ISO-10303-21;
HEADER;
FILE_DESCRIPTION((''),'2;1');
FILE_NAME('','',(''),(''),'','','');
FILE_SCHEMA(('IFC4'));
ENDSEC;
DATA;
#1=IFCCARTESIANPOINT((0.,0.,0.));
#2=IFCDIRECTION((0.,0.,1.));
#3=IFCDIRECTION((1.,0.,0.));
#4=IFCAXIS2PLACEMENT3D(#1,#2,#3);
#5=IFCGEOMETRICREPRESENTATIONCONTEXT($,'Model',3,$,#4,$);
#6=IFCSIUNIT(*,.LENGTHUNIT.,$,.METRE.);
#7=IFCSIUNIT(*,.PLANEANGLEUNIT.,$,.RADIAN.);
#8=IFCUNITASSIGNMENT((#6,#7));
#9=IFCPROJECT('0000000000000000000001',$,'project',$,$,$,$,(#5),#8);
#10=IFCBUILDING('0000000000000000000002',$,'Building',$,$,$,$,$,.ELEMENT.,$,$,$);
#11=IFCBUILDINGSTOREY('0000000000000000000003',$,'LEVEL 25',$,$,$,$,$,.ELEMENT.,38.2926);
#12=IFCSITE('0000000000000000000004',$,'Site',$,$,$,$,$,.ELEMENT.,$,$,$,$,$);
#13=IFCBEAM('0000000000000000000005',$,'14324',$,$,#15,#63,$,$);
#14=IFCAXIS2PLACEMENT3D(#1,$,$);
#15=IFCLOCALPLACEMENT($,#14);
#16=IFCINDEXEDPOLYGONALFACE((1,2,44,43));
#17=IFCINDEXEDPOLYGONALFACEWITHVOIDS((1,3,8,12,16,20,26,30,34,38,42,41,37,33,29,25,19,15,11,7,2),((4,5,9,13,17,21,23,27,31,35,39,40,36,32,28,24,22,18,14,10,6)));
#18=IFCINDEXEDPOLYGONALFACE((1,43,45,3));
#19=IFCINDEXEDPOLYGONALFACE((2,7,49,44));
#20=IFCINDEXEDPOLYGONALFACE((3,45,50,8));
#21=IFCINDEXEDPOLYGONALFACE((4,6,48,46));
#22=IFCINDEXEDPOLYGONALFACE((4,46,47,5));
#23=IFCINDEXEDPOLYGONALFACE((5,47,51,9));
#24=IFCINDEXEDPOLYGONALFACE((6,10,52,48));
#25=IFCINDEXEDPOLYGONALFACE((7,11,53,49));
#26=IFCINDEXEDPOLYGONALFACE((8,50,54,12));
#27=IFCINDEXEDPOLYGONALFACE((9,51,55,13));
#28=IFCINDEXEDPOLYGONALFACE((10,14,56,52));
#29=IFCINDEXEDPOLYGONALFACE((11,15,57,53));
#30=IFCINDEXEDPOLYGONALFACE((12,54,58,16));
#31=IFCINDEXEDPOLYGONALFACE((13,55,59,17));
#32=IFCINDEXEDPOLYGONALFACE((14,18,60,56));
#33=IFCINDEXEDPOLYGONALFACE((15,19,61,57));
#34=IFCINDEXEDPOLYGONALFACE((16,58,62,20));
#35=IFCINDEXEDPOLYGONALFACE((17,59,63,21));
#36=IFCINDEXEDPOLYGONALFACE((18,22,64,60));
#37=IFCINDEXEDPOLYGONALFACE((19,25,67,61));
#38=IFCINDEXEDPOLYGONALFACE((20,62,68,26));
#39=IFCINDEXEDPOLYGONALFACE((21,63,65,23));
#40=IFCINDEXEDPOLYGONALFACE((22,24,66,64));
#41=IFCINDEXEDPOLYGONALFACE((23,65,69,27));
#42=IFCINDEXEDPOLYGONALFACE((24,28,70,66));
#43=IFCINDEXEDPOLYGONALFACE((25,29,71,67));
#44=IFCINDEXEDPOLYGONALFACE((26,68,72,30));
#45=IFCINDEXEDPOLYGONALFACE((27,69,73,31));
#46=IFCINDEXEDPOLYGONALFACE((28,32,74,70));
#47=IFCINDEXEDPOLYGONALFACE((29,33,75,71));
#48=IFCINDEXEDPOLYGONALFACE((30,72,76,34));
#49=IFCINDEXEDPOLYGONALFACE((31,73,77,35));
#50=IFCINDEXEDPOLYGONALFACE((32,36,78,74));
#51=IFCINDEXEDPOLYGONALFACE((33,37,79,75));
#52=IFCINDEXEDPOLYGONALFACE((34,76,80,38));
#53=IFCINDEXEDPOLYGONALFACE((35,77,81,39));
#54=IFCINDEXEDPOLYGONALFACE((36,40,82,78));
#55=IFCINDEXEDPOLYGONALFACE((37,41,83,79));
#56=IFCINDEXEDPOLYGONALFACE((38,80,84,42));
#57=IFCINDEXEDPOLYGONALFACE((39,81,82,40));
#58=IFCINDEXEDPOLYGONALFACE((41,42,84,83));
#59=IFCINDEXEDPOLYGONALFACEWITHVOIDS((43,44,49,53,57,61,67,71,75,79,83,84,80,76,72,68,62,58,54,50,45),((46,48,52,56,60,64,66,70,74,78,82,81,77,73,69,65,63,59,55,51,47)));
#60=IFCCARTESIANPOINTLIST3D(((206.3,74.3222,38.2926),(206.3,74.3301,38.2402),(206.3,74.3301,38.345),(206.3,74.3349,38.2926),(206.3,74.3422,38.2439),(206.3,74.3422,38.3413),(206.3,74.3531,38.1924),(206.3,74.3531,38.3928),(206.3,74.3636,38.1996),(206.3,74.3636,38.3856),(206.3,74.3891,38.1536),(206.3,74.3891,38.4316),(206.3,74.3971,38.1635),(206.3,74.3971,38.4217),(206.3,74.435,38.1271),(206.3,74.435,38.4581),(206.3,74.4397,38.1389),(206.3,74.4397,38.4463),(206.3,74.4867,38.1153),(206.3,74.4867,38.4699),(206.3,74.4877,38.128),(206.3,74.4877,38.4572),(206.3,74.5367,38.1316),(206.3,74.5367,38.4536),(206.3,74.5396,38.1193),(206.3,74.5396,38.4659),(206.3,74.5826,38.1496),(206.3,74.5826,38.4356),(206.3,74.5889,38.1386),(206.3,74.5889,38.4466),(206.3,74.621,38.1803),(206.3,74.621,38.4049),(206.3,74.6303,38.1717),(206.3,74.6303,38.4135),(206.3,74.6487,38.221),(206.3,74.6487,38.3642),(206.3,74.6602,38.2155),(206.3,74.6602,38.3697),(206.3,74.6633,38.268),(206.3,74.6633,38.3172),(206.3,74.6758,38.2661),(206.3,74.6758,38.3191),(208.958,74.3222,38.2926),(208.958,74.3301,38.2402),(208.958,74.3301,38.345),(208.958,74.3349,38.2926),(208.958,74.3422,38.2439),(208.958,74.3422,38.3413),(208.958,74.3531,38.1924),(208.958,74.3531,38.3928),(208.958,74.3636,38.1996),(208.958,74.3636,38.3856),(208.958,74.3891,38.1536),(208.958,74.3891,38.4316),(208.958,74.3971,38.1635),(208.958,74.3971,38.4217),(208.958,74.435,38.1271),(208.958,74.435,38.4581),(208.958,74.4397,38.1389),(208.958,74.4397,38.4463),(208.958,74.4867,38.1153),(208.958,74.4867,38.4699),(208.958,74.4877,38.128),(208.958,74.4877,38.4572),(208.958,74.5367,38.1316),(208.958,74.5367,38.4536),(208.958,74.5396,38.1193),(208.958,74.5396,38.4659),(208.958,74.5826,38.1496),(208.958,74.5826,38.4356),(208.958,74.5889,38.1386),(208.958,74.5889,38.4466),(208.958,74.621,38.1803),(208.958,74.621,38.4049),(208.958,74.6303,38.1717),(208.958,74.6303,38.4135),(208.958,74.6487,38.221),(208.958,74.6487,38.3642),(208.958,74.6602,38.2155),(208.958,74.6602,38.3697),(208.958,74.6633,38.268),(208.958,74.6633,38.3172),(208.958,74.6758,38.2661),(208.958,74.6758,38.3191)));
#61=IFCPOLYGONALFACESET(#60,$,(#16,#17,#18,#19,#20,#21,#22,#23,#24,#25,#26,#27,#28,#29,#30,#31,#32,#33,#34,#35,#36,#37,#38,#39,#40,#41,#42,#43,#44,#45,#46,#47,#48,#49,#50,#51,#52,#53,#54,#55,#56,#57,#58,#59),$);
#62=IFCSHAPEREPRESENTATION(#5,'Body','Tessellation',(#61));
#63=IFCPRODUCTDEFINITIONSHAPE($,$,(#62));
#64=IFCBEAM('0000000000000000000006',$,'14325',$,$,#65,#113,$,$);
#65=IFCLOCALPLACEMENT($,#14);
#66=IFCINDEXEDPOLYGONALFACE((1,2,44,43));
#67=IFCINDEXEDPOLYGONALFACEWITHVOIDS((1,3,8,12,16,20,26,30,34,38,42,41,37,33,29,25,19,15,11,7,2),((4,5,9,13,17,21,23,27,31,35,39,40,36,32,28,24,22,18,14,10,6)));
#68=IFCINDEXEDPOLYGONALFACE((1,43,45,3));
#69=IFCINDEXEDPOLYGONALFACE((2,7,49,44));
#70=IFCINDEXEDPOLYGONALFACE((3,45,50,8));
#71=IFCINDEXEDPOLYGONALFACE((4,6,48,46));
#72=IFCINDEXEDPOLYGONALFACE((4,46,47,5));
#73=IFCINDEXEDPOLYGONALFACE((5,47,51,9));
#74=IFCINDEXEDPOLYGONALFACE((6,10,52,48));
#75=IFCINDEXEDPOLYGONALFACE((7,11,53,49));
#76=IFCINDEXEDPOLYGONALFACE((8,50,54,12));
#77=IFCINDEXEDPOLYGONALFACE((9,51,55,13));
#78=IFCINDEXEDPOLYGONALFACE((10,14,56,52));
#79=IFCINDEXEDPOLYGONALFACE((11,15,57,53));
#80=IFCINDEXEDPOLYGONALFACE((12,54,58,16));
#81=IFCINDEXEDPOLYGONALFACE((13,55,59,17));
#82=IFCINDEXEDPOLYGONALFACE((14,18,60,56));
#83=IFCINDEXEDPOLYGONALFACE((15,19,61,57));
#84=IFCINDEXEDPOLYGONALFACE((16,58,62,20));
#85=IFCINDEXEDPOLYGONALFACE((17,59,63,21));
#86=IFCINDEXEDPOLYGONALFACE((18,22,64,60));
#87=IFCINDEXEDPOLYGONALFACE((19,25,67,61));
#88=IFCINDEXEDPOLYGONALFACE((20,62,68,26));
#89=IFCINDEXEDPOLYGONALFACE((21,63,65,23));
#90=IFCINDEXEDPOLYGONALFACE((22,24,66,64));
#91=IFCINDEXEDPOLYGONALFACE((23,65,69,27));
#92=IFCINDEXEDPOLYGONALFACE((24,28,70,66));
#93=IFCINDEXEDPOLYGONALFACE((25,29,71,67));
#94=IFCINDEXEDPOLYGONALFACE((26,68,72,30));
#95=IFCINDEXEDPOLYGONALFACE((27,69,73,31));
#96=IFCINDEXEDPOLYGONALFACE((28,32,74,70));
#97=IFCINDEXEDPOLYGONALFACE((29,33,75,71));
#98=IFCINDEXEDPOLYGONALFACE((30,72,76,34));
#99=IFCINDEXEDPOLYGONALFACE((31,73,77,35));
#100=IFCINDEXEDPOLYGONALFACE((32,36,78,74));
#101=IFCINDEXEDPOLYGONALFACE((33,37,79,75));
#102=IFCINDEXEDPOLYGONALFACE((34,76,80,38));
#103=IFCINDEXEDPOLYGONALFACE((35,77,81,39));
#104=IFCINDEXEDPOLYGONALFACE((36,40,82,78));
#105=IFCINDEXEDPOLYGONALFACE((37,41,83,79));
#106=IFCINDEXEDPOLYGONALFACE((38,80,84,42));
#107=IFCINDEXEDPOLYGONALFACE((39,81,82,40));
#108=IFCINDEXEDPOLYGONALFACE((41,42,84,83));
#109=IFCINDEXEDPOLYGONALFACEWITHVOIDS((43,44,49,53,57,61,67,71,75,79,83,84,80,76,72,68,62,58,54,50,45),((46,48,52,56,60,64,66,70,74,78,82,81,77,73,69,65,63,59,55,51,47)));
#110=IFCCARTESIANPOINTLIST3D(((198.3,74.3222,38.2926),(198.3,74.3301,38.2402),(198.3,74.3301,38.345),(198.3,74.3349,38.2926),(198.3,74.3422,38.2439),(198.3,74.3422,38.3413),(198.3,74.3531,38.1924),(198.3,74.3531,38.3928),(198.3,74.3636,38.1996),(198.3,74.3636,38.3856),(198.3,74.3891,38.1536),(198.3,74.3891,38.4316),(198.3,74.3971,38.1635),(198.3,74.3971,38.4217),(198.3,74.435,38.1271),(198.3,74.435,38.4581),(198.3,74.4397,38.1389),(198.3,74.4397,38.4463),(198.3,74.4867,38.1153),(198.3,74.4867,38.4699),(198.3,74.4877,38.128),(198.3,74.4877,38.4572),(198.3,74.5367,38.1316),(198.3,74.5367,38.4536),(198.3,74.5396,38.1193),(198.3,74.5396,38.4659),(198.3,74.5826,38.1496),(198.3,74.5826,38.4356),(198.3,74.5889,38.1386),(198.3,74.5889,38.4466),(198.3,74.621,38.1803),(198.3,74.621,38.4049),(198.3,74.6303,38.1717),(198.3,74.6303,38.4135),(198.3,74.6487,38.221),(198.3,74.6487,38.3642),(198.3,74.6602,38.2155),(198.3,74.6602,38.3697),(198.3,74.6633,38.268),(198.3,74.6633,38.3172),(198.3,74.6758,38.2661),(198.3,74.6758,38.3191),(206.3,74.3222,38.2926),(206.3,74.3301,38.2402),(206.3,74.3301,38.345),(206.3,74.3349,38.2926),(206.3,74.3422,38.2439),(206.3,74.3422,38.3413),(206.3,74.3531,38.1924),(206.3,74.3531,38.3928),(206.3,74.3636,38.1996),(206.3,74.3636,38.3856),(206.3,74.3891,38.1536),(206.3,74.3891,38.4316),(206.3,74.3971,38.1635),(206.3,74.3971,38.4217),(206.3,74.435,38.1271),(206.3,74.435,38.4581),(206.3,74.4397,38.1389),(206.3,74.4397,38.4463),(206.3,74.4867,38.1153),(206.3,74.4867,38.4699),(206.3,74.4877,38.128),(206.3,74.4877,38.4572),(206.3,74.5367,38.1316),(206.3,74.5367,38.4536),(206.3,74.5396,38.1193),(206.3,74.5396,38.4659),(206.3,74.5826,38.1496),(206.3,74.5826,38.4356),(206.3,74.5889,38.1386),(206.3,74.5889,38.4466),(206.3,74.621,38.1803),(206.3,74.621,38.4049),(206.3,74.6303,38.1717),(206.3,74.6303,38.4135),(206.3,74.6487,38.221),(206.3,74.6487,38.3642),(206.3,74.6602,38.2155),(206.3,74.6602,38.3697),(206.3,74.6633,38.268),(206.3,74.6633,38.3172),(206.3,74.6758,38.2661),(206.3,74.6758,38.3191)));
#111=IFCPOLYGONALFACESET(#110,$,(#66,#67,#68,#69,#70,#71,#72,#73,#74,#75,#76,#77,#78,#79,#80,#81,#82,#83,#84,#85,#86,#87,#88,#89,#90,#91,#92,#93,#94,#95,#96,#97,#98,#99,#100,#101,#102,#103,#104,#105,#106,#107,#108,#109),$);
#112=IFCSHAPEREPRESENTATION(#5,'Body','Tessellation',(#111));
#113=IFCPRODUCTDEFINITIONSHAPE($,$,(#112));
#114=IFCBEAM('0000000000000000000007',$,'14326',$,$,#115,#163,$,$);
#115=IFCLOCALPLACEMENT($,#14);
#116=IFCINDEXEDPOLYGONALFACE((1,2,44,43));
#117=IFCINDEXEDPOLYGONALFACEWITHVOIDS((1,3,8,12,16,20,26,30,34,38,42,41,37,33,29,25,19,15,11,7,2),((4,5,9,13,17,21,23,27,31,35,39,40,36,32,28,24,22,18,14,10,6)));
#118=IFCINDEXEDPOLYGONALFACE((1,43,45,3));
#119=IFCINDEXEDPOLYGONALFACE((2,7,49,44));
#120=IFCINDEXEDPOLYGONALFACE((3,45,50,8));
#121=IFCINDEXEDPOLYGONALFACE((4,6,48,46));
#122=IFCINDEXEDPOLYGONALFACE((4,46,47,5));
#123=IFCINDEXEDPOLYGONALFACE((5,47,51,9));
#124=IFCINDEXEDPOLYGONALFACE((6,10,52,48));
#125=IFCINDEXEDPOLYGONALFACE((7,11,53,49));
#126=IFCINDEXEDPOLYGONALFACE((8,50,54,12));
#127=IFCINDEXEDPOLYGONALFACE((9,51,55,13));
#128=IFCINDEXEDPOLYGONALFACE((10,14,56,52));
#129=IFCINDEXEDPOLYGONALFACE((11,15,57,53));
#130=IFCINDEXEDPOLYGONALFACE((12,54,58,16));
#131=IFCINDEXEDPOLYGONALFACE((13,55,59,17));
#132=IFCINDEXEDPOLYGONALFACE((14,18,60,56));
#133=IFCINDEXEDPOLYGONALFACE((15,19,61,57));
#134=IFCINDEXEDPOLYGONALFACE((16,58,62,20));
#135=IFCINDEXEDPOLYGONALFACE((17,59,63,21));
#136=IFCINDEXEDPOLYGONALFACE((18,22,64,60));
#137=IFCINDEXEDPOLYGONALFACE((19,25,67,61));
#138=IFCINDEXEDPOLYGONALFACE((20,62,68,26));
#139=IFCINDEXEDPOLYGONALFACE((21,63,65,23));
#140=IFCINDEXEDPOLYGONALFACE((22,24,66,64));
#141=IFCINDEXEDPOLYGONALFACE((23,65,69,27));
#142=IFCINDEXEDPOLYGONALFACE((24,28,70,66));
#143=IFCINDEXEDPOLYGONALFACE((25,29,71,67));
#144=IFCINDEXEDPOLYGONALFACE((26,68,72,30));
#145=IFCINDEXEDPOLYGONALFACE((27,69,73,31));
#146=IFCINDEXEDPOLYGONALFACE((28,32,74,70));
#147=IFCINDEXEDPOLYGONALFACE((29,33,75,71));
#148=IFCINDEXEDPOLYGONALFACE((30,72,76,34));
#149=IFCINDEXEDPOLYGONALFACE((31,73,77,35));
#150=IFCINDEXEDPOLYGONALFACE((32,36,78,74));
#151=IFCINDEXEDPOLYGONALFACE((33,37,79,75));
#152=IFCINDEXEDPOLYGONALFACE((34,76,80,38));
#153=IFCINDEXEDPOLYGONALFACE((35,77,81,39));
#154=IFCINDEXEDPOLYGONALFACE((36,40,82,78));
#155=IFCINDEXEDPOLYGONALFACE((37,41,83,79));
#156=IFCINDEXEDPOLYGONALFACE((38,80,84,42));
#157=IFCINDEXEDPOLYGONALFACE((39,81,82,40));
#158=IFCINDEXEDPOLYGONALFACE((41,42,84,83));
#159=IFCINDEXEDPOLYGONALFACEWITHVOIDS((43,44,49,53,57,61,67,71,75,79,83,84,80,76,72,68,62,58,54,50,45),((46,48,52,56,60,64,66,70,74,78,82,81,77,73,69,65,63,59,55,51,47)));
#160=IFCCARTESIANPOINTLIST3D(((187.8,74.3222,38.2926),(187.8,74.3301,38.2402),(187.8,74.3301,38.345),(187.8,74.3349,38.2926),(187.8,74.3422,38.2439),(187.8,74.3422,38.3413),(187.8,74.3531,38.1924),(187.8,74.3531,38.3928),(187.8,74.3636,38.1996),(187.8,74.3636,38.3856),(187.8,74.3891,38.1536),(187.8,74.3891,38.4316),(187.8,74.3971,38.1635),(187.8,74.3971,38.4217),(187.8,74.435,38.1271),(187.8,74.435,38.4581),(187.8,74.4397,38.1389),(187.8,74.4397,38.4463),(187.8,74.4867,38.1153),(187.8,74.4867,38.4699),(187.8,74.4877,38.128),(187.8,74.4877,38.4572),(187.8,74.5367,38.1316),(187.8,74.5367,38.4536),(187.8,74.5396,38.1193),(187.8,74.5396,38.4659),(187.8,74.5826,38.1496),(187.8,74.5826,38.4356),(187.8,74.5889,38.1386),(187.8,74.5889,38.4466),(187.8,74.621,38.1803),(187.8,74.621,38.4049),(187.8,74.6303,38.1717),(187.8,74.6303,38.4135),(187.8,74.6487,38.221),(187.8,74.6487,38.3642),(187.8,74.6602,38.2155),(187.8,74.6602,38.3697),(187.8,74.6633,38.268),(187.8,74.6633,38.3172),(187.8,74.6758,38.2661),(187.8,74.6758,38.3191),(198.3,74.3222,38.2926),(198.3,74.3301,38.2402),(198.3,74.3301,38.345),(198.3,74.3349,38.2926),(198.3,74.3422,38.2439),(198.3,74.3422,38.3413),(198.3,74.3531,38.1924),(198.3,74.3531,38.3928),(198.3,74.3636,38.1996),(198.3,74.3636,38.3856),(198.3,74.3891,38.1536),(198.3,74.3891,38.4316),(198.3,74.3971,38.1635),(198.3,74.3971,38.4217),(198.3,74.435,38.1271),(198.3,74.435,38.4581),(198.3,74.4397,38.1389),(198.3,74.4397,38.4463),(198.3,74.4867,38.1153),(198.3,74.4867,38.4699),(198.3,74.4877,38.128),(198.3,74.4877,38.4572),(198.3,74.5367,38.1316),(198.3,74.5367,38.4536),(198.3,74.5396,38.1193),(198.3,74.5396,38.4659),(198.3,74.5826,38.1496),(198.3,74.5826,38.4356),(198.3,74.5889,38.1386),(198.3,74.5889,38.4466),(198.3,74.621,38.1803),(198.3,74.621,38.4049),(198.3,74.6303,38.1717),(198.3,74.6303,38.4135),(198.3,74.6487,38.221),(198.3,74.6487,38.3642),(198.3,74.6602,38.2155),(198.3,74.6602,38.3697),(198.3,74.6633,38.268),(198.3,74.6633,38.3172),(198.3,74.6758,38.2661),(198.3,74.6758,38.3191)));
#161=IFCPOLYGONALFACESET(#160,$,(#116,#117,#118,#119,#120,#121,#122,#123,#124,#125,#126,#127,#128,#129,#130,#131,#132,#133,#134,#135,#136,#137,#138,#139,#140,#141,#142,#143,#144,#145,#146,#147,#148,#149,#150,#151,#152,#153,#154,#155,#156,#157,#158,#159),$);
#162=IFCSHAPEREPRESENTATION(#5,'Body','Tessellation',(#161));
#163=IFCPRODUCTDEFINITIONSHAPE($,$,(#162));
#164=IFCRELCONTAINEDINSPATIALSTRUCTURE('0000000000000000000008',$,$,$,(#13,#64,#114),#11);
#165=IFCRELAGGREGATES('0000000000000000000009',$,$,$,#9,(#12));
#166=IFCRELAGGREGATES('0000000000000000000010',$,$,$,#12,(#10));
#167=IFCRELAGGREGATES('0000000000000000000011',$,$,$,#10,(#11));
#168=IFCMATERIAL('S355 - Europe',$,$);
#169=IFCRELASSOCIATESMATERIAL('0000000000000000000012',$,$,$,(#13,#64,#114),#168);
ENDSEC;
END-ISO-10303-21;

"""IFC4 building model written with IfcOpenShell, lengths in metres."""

from ifc_helpers import new_model, si_unit, frame, origin_with_axes, origin_2d_with_axis, place, context, project, spatial, hollow_circle, extrude, material, material_profile, profile_set, profile_usage, element, save


model = new_model("IFC4")

# Units and contexts
model_context = context("Model", 3, world=origin_with_axes())
ifc_project = project(units=[si_unit("LENGTHUNIT", "METRE"), si_unit("PLANEANGLEUNIT", "RADIAN")], contexts=[model_context])

# Site, building, storey
site = spatial("IfcSite", under=ifc_project, Name="Site", CompositionType="ELEMENT")
building = spatial("IfcBuilding", under=site, Name="Building", CompositionType="ELEMENT")
storey = spatial("IfcBuildingStorey", under=building, Name="LEVEL 25", CompositionType="ELEMENT", Elevation=38.2926)

# Beams
ifc_material = material(Name="S355 - Europe")
ifc_material_profile_1 = material_profile(ifc_material, hollow_circle(Radius=0.1778, WallThickness=0.0127, at=origin_2d_with_axis()))
ifc_profile_set_1 = profile_set([ifc_material_profile_1])
ifc_profile_usage_1 = profile_usage(ifc_profile_set_1, cardinal=10)
beam_1_placement = place(None, frame((208.958, 74.5, 38.2926), z_axis=(-1.0, 0.0, 0.0), x_axis=(0.0, -1.0, 0.0)))
element("IfcBeam", 1, at=beam_1_placement, inside=storey, material=ifc_profile_usage_1, Name="14324", context=model_context, shape_type="SweptSolid", body=[
    extrude(hollow_circle(Radius=0.1778, WallThickness=0.0127, at=origin_2d_with_axis()), origin_with_axes(), (0.0, 0.0, 1.0), 2.658),
])
ifc_material_profile_2 = material_profile(ifc_material, hollow_circle(Radius=0.1778, WallThickness=0.0127, at=origin_2d_with_axis()))
ifc_profile_set_2 = profile_set([ifc_material_profile_2])
ifc_profile_usage_2 = profile_usage(ifc_profile_set_2, cardinal=10)
beam_2_placement = place(None, frame((206.3, 74.5, 38.2926), z_axis=(-1.0, 0.0, 0.0), x_axis=(0.0, -1.0, 0.0)))
element("IfcBeam", 2, at=beam_2_placement, inside=storey, material=ifc_profile_usage_2, Name="14325", context=model_context, shape_type="SweptSolid", body=[
    extrude(hollow_circle(Radius=0.1778, WallThickness=0.0127, at=origin_2d_with_axis()), origin_with_axes(), (0.0, 0.0, 1.0), 8.0),
])
ifc_material_profile_3 = material_profile(ifc_material, hollow_circle(Radius=0.1778, WallThickness=0.0127, at=origin_2d_with_axis()))
ifc_profile_set_3 = profile_set([ifc_material_profile_3])
ifc_profile_usage_3 = profile_usage(ifc_profile_set_3, cardinal=10)
beam_3_placement = place(None, frame((198.3, 74.5, 38.2926), z_axis=(-1.0, 0.0, 0.0), x_axis=(0.0, -1.0, 0.0)))
element("IfcBeam", 3, at=beam_3_placement, inside=storey, material=ifc_profile_usage_3, Name="14326", context=model_context, shape_type="SweptSolid", body=[
    extrude(hollow_circle(Radius=0.1778, WallThickness=0.0127, at=origin_2d_with_axis()), origin_with_axes(), (0.0, 0.0, 1.0), 10.5),
])

save(model, "model.ifc")
